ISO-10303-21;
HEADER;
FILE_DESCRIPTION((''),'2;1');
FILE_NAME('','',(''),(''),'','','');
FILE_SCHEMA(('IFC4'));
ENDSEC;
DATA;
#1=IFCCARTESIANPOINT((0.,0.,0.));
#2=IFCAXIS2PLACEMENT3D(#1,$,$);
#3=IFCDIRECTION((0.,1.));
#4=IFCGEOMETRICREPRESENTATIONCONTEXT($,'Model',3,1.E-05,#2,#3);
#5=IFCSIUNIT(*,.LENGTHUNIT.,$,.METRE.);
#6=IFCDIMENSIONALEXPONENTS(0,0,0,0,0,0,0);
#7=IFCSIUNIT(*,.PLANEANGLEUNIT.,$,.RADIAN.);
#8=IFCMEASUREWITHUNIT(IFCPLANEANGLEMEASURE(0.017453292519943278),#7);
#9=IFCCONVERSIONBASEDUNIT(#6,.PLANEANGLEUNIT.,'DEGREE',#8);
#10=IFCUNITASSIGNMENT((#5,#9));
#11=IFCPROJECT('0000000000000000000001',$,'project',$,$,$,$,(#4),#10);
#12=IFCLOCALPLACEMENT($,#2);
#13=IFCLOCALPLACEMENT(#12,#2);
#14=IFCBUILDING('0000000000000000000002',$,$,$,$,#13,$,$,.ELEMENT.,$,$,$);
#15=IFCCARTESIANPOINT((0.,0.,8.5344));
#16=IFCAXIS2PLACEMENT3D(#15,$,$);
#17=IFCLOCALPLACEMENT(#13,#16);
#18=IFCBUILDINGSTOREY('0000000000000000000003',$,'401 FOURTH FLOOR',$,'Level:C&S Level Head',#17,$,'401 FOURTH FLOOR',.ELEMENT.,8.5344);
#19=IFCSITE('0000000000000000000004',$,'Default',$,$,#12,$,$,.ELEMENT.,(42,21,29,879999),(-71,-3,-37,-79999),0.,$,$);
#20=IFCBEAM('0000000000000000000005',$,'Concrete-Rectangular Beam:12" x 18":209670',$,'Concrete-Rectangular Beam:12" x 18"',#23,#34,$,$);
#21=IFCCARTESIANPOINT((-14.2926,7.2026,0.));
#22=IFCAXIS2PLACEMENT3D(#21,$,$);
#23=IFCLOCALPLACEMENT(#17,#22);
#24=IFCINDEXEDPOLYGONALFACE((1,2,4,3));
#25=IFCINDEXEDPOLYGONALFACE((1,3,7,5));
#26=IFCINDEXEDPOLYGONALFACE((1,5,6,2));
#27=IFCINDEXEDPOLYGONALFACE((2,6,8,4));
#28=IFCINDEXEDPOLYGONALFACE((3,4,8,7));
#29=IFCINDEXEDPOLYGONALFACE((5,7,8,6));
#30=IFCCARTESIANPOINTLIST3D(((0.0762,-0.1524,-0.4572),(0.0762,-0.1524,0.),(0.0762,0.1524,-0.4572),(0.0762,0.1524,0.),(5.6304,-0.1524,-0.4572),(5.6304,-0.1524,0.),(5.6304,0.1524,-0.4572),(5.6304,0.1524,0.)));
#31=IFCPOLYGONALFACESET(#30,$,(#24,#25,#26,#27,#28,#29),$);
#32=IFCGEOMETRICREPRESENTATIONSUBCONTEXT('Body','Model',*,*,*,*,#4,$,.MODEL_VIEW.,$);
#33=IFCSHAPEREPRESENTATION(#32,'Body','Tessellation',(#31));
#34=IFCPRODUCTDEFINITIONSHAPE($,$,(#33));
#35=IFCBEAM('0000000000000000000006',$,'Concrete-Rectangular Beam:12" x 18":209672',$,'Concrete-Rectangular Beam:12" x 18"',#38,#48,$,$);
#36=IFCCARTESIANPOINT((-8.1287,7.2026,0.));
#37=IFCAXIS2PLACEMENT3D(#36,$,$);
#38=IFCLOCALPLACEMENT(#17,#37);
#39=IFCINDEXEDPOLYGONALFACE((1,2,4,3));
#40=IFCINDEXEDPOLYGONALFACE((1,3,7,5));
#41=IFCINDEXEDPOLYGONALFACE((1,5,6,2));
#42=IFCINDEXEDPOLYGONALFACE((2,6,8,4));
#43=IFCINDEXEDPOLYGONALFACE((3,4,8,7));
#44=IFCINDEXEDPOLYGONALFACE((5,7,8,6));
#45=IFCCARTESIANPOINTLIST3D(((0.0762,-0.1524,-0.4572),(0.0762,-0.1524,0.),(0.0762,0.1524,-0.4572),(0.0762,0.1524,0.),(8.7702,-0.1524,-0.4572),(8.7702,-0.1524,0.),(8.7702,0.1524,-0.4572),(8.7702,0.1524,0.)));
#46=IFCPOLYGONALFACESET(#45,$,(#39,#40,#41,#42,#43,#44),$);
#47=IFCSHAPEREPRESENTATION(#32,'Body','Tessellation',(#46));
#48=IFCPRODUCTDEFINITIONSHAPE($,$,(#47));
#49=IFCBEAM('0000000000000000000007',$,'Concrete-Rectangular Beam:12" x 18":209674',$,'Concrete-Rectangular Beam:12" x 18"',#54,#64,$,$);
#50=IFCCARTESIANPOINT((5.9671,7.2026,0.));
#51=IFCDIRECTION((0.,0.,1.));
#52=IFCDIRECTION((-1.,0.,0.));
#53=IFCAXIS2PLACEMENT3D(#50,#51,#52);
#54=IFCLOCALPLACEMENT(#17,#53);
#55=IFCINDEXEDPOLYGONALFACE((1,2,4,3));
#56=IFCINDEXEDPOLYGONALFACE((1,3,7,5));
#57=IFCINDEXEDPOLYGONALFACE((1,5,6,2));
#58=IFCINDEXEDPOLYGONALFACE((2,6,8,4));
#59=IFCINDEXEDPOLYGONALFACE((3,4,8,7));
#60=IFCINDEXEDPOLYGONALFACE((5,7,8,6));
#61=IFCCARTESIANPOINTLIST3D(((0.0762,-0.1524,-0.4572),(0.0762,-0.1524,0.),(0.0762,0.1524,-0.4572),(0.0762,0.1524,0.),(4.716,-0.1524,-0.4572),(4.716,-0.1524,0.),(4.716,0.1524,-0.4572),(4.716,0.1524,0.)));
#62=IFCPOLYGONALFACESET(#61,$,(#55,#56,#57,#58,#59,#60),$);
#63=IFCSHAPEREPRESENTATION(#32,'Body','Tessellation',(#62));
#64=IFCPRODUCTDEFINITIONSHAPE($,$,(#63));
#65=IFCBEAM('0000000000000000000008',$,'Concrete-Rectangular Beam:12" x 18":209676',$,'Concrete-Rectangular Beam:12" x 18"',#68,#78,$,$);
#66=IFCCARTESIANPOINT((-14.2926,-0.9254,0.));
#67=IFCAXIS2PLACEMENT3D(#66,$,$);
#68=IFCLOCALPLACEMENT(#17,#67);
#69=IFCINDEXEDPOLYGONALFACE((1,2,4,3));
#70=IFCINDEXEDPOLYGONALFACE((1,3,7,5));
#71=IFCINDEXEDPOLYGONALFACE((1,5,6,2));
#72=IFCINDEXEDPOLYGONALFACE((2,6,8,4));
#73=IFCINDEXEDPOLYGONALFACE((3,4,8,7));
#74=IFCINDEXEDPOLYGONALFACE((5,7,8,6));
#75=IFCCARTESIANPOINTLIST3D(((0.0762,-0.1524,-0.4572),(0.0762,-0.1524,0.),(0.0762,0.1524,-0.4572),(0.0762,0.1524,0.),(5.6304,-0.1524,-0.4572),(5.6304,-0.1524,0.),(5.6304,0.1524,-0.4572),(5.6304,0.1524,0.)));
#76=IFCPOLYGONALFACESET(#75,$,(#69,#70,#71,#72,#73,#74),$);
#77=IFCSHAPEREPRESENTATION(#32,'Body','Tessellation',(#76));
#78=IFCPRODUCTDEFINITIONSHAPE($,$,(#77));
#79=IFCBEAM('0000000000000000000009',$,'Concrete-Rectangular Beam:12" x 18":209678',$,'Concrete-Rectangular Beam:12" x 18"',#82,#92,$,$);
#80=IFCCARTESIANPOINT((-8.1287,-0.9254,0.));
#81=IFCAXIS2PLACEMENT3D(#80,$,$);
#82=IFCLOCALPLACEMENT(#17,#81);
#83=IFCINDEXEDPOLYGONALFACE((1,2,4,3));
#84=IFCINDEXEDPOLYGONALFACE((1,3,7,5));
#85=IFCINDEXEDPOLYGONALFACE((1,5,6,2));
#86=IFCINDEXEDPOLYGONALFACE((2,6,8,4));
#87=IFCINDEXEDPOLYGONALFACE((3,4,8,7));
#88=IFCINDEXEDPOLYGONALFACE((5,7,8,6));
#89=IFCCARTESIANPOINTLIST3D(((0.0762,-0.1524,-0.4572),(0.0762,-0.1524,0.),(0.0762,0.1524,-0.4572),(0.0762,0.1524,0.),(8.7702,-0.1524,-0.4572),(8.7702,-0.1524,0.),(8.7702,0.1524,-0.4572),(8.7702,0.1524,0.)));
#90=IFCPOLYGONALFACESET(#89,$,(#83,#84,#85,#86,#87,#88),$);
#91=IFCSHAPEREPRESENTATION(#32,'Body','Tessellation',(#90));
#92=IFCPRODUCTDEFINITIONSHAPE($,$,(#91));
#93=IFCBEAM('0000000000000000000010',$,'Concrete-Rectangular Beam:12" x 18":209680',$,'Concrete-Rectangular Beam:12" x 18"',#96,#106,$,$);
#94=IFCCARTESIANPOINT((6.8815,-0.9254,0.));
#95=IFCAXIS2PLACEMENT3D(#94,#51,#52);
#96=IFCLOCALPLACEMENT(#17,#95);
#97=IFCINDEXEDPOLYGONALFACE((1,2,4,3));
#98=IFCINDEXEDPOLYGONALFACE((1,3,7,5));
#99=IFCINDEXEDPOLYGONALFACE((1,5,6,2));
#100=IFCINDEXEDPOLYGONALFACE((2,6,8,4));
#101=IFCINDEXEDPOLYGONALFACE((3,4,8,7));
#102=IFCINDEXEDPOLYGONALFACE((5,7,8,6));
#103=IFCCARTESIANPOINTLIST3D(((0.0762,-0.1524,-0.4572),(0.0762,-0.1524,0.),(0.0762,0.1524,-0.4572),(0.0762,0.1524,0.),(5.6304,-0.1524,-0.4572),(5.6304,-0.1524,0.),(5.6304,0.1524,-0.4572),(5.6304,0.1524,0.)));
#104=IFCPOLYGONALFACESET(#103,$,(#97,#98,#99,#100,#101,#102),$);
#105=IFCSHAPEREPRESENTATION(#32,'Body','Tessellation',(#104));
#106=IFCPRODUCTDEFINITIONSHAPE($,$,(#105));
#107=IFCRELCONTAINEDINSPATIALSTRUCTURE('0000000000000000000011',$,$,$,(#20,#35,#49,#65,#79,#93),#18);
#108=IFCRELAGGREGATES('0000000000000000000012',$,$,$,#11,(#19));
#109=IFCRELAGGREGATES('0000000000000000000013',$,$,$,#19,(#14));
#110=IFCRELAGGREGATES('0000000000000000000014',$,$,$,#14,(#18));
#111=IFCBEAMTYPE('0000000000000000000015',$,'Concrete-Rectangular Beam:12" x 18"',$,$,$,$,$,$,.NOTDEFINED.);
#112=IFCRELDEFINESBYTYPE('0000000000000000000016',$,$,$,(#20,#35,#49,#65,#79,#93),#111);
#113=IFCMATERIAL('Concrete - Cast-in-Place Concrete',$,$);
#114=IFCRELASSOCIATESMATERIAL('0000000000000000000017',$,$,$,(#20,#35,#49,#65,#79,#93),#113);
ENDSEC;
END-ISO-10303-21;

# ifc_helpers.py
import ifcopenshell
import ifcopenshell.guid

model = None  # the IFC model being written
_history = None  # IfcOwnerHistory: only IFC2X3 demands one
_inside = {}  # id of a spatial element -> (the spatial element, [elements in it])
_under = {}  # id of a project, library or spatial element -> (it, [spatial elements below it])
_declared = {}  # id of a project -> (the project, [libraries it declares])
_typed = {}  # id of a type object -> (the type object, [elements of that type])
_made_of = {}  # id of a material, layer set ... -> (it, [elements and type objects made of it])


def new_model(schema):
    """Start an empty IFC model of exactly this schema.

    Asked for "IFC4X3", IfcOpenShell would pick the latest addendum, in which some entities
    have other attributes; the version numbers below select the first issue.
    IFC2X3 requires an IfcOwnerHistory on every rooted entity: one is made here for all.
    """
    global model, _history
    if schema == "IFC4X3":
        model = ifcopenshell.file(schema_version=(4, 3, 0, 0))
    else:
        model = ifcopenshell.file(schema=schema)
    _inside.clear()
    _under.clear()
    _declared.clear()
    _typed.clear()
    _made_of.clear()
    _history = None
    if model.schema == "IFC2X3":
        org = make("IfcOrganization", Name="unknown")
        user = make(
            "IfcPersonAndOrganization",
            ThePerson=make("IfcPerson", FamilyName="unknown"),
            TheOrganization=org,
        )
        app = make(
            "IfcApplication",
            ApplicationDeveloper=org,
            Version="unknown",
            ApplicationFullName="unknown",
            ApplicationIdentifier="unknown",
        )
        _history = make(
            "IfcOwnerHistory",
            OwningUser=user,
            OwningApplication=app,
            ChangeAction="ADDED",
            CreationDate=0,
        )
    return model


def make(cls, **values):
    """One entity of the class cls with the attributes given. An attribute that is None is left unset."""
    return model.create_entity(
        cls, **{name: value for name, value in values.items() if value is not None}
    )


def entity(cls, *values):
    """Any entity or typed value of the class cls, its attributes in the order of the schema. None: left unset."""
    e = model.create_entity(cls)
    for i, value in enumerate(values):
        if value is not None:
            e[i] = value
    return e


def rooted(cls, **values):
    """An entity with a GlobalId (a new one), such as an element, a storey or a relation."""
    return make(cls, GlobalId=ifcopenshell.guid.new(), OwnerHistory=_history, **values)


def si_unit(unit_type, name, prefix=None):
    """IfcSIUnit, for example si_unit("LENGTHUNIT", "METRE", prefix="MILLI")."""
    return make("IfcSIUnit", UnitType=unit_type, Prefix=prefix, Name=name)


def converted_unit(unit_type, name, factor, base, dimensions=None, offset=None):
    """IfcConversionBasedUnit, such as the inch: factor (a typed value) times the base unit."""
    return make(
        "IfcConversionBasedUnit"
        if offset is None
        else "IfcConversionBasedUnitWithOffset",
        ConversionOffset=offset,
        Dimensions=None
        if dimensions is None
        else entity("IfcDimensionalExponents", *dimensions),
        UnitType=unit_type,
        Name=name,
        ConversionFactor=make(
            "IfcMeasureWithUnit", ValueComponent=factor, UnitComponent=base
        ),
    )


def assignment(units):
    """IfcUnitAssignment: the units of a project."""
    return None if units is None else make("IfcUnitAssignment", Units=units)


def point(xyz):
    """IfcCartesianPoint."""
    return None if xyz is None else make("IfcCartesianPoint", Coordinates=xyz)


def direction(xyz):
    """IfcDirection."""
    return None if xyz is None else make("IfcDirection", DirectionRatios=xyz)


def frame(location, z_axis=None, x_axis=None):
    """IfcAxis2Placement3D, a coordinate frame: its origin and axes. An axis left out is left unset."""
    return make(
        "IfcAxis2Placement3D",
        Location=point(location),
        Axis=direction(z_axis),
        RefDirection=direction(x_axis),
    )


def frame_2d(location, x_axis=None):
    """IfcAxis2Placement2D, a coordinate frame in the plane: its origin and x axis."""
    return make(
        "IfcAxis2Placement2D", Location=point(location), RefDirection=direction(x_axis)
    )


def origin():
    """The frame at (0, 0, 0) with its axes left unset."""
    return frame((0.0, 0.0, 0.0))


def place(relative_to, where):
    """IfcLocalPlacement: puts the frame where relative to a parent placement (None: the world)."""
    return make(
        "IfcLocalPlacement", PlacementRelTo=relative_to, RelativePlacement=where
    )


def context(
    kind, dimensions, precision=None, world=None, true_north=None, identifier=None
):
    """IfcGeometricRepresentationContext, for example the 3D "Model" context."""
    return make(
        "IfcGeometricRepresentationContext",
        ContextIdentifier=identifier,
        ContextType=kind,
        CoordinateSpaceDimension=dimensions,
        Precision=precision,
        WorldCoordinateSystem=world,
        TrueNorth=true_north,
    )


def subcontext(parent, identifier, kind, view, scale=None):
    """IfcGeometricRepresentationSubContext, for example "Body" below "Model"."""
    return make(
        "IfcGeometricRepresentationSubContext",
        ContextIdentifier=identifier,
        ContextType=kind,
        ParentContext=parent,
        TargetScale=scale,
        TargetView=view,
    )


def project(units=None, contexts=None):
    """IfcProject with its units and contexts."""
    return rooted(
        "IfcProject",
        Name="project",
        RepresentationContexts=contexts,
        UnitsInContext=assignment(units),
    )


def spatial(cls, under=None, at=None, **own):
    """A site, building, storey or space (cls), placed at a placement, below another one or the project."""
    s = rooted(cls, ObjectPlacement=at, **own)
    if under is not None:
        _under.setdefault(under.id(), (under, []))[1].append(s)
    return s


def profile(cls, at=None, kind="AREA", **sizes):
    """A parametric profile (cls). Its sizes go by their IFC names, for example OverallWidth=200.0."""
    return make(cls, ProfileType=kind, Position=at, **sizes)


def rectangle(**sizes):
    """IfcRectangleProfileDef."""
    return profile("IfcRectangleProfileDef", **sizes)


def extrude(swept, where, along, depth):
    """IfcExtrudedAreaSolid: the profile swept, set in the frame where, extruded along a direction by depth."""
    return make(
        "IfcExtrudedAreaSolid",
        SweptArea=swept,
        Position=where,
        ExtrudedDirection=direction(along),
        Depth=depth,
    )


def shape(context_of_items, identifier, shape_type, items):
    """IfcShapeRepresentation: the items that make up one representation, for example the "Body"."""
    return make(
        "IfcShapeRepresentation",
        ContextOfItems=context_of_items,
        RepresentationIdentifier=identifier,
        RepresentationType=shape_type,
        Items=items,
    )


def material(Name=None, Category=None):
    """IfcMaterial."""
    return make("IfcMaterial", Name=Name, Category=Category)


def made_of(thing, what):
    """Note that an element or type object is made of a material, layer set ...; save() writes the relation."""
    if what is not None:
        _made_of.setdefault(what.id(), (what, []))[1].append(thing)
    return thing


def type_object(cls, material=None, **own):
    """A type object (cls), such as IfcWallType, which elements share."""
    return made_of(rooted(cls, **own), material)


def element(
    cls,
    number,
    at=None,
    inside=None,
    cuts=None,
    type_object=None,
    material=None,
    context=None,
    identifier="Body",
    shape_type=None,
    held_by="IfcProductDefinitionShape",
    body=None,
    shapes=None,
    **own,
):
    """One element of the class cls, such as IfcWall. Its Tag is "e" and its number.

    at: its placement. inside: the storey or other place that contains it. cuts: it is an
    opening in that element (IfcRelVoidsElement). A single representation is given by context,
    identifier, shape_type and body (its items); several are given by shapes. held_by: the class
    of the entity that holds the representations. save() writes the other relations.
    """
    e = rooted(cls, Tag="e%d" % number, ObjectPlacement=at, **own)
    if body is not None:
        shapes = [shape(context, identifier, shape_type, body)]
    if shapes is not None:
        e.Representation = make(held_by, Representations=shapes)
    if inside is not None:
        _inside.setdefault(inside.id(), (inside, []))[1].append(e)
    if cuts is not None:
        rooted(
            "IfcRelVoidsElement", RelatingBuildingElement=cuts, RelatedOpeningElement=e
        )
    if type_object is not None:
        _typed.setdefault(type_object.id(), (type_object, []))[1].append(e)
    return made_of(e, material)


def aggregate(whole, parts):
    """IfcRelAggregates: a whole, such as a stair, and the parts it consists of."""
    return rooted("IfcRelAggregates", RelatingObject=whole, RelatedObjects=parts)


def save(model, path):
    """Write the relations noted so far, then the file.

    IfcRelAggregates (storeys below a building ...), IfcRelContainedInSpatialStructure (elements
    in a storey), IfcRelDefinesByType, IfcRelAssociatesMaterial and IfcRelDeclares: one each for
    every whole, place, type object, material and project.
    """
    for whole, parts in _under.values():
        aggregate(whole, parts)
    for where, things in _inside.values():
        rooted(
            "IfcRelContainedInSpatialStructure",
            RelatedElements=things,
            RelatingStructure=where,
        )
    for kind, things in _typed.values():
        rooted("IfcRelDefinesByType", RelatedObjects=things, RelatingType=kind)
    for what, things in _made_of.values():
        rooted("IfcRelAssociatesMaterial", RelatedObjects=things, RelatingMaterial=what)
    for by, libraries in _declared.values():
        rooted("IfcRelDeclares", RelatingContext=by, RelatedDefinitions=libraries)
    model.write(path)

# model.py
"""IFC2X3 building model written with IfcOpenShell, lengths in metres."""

from ifc_helpers import new_model, entity, si_unit, converted_unit, direction, frame, frame_2d, origin, place, context, subcontext, project, spatial, rectangle, extrude, material, type_object, element, save


model = new_model("IFC2X3")

# Units and contexts
model_context = context("Model", 3, precision=1e-05, world=origin(), true_north=direction((0.0, 1.0)))
body_context = subcontext(model_context, "Body", "Model", "MODEL_VIEW")
ifc_project = project(units=[si_unit("LENGTHUNIT", "METRE"), converted_unit("PLANEANGLEUNIT", "DEGREE", entity("IfcPlaneAngleMeasure", 0.017453292519943278), si_unit("PLANEANGLEUNIT", "RADIAN"), dimensions=[0, 0, 0, 0, 0, 0, 0])], contexts=[model_context])

# Site, building, storey
site_placement = place(None, origin())
site = spatial("IfcSite", under=ifc_project, at=site_placement, Name="Default", CompositionType="ELEMENT", RefLatitude=(42, 21, 29, 879999), RefLongitude=(-71, -3, -37, -79999), RefElevation=0.0)
building_placement = place(site_placement, origin())
building = spatial("IfcBuilding", under=site, at=building_placement, CompositionType="ELEMENT")
storey_placement = place(building_placement, frame((0.0, 0.0, 8.5344)))
storey = spatial("IfcBuildingStorey", under=building, at=storey_placement, Name="401 FOURTH FLOOR", ObjectType="Level:C&S Level Head", LongName="401 FOURTH FLOOR", CompositionType="ELEMENT", Elevation=8.5344)

# Beams
ifc_material_1 = material(Name="Concrete - Cast-in-Place Concrete")
beam_type = type_object("IfcBeamType", Name="Concrete-Rectangular Beam:12\" x 18\"", PredefinedType="NOTDEFINED")
beam_1_placement = place(storey_placement, frame((-14.2926, 7.2026, 0.0)))
element("IfcBeam", 1, at=beam_1_placement, inside=storey, type_object=beam_type, material=ifc_material_1, Name="Concrete-Rectangular Beam:12\" x 18\":209670", ObjectType="Concrete-Rectangular Beam:12\" x 18\"", context=body_context, shape_type="SweptSolid", body=[
    extrude(rectangle(XDim=0.4572, YDim=0.3048, at=frame_2d((0.0, 0.0), x_axis=(1.0, 0.0))), frame((0.0762, 0.0, -0.2286), z_axis=(1.0, 0.0, 0.0), x_axis=(0.0, 0.0, -1.0)), (0.0, 0.0, 1.0), 5.5542),
])
beam_2_placement = place(storey_placement, frame((-8.1287, 7.2026, 0.0)))
element("IfcBeam", 2, at=beam_2_placement, inside=storey, type_object=beam_type, material=ifc_material_1, Name="Concrete-Rectangular Beam:12\" x 18\":209672", ObjectType="Concrete-Rectangular Beam:12\" x 18\"", context=body_context, shape_type="SweptSolid", body=[
    extrude(rectangle(XDim=0.4572, YDim=0.3048, at=frame_2d((0.0, 0.0), x_axis=(1.0, 0.0))), frame((0.0762, 0.0, -0.2286), z_axis=(1.0, 0.0, 0.0), x_axis=(0.0, 0.0, -1.0)), (0.0, 0.0, 1.0), 8.694),
])
beam_3_placement = place(storey_placement, frame((5.9671, 7.2026, 0.0), z_axis=(0.0, 0.0, 1.0), x_axis=(-1.0, 0.0, 0.0)))
element("IfcBeam", 3, at=beam_3_placement, inside=storey, type_object=beam_type, material=ifc_material_1, Name="Concrete-Rectangular Beam:12\" x 18\":209674", ObjectType="Concrete-Rectangular Beam:12\" x 18\"", context=body_context, shape_type="SweptSolid", body=[
    extrude(rectangle(XDim=0.4572, YDim=0.3048, at=frame_2d((0.0, 0.0), x_axis=(1.0, 0.0))), frame((0.0762, 0.0, -0.2286), z_axis=(1.0, 0.0, 0.0), x_axis=(0.0, 0.0, -1.0)), (0.0, 0.0, 1.0), 4.6398),
])
beam_4_placement = place(storey_placement, frame((-14.2926, -0.9254, 0.0)))
element("IfcBeam", 4, at=beam_4_placement, inside=storey, type_object=beam_type, material=ifc_material_1, Name="Concrete-Rectangular Beam:12\" x 18\":209676", ObjectType="Concrete-Rectangular Beam:12\" x 18\"", context=body_context, shape_type="SweptSolid", body=[
    extrude(rectangle(XDim=0.4572, YDim=0.3048, at=frame_2d((0.0, 0.0), x_axis=(1.0, 0.0))), frame((0.0762, 0.0, -0.2286), z_axis=(1.0, 0.0, 0.0), x_axis=(0.0, 0.0, -1.0)), (0.0, 0.0, 1.0), 5.5542),
])
beam_5_placement = place(storey_placement, frame((-8.1287, -0.9254, 0.0)))
element("IfcBeam", 5, at=beam_5_placement, inside=storey, type_object=beam_type, material=ifc_material_1, Name="Concrete-Rectangular Beam:12\" x 18\":209678", ObjectType="Concrete-Rectangular Beam:12\" x 18\"", context=body_context, shape_type="SweptSolid", body=[
    extrude(rectangle(XDim=0.4572, YDim=0.3048, at=frame_2d((0.0, 0.0), x_axis=(1.0, 0.0))), frame((0.0762, 0.0, -0.2286), z_axis=(1.0, 0.0, 0.0), x_axis=(0.0, 0.0, -1.0)), (0.0, 0.0, 1.0), 8.694),
])
beam_6_placement = place(storey_placement, frame((6.8815, -0.9254, 0.0), z_axis=(0.0, 0.0, 1.0), x_axis=(-1.0, 0.0, 0.0)))
element("IfcBeam", 6, at=beam_6_placement, inside=storey, type_object=beam_type, material=ifc_material_1, Name="Concrete-Rectangular Beam:12\" x 18\":209680", ObjectType="Concrete-Rectangular Beam:12\" x 18\"", context=body_context, shape_type="SweptSolid", body=[
    extrude(rectangle(XDim=0.4572, YDim=0.3048, at=frame_2d((0.0, 0.0), x_axis=(1.0, 0.0))), frame((0.0762, 0.0, -0.2286), z_axis=(1.0, 0.0, 0.0), x_axis=(0.0, 0.0, -1.0)), (0.0, 0.0, 1.0), 5.5542),
])

save(model, "model.ifc")
